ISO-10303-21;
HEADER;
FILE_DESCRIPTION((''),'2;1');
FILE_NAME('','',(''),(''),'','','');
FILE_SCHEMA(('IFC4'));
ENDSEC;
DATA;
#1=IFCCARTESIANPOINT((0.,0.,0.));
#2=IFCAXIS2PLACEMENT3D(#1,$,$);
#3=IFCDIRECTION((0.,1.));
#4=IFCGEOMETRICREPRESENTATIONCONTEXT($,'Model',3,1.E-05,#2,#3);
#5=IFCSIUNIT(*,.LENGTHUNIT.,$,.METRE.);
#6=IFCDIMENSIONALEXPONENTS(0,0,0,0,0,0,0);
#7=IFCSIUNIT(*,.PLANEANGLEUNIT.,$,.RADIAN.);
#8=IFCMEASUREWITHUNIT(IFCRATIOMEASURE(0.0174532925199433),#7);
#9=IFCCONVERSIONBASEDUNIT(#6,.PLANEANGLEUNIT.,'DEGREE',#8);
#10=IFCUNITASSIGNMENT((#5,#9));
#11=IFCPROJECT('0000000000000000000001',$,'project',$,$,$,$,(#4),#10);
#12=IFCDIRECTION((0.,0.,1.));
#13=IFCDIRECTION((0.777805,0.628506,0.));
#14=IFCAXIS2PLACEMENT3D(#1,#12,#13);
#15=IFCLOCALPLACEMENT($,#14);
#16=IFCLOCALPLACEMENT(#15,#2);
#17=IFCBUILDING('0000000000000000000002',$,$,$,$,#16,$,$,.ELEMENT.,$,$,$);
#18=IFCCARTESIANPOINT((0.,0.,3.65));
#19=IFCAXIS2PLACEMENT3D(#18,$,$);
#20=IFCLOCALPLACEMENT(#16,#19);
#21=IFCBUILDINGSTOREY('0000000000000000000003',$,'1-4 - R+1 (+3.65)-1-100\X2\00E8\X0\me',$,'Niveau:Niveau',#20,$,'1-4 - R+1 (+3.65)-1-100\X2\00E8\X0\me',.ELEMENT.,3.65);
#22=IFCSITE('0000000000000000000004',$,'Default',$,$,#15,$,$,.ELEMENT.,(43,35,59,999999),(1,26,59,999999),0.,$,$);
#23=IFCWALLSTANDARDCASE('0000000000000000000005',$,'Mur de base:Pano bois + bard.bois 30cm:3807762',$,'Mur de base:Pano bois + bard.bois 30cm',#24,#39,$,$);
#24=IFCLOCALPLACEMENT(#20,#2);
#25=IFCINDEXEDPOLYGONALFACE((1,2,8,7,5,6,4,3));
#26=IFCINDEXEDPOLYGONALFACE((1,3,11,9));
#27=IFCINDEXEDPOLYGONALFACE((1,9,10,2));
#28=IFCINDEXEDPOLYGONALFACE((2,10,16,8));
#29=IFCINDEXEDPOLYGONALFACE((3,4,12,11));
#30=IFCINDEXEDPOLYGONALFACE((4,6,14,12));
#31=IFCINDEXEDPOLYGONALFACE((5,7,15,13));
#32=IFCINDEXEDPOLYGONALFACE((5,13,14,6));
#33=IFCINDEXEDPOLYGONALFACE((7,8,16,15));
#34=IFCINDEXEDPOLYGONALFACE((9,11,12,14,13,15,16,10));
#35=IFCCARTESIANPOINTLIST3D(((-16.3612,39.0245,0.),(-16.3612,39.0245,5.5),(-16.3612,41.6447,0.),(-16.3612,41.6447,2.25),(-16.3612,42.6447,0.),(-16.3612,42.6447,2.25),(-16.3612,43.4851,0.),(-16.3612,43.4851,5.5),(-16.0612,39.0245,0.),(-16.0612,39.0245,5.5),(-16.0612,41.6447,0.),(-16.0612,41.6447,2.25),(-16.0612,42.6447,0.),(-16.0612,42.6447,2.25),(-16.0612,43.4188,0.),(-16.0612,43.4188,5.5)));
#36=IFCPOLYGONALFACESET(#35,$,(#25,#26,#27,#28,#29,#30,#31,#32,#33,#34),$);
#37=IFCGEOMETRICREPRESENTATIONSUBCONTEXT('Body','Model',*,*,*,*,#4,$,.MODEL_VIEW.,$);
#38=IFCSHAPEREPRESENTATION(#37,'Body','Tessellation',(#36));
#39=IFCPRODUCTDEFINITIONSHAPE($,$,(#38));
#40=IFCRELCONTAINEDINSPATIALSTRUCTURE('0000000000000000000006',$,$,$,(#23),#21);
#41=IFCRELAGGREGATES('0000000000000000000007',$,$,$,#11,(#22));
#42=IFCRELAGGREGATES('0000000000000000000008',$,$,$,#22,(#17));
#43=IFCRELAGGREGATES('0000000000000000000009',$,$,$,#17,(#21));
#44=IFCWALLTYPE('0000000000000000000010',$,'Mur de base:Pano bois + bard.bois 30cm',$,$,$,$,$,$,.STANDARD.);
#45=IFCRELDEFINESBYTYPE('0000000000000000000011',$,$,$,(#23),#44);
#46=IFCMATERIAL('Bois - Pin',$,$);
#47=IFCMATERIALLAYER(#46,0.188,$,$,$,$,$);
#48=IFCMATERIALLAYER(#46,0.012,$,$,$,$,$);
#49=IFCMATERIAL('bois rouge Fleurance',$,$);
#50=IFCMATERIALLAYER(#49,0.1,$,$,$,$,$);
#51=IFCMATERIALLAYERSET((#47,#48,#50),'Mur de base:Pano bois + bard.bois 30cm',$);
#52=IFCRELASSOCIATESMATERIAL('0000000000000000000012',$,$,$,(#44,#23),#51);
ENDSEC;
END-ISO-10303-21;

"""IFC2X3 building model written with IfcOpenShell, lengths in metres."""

from ifc_helpers import new_model, entity, si_unit, converted_unit, direction, frame, frame_2d, origin, place, context, subcontext, project, spatial, polyline, rectangle, outline, extrude, material, layer, layer_set, layer_usage, type_object, element, save


model = new_model("IFC2X3")

# Units and contexts
model_context = context("Model", 3, precision=1e-05, world=origin(), true_north=direction((0.0, 1.0)))
body_context = subcontext(model_context, "Body", "Model", "MODEL_VIEW")
ifc_project = project(units=[si_unit("LENGTHUNIT", "METRE"), converted_unit("PLANEANGLEUNIT", "DEGREE", entity("IfcRatioMeasure", 0.0174532925199433), si_unit("PLANEANGLEUNIT", "RADIAN"), dimensions=[0, 0, 0, 0, 0, 0, 0])], contexts=[model_context])

# Site, building, storey
site_placement = place(None, frame((0.0, 0.0, 0.0), z_axis=(0.0, 0.0, 1.0), x_axis=(0.777805, 0.628506, 0.0)))
site = spatial("IfcSite", under=ifc_project, at=site_placement, Name="Default", CompositionType="ELEMENT", RefLatitude=(43, 35, 59, 999999), RefLongitude=(1, 26, 59, 999999), RefElevation=0.0)
building_placement = place(site_placement, origin())
building = spatial("IfcBuilding", under=site, at=building_placement, CompositionType="ELEMENT")
storey_placement = place(building_placement, frame((0.0, 0.0, 3.65)))
storey = spatial("IfcBuildingStorey", under=building, at=storey_placement, Name="1-4 - R+1 (+3.65)-1-100ème", ObjectType="Niveau:Niveau", LongName="1-4 - R+1 (+3.65)-1-100ème", CompositionType="ELEMENT", Elevation=3.65)

# Shared definitions
ifc_material_1 = material(Name="Bois - Pin")
ifc_material_2 = material(Name="bois rouge Fleurance")

# Wall, opening
ifc_layer_1 = layer(ifc_material_1, 0.188)
ifc_layer_2 = layer(ifc_material_1, 0.012)
ifc_layer_3 = layer(ifc_material_2, 0.1)
ifc_layer_set_1 = layer_set([ifc_layer_1, ifc_layer_2, ifc_layer_3], Name="Mur de base:Pano bois + bard.bois 30cm")
ifc_layer_usage_1 = layer_usage(ifc_layer_set_1, "AXIS2", "POSITIVE", -0.15)
wall_type_1 = type_object("IfcWallType", Name="Mur de base:Pano bois + bard.bois 30cm", PredefinedType="STANDARD", material=ifc_layer_set_1)
wall_1_placement = place(storey_placement, frame((-16.2112, 43.4851, 0.0), z_axis=(0.0, 0.0, 1.0), x_axis=(0.0, -1.0, 0.0)))
wall_1 = element("IfcWallStandardCase", 1, at=wall_1_placement, inside=storey, type_object=wall_type_1, material=ifc_layer_usage_1, Name="Mur de base:Pano bois + bard.bois 30cm:3807762", ObjectType="Mur de base:Pano bois + bard.bois 30cm", context=body_context, shape_type="SweptSolid", body=[
    extrude(outline(polyline([(0.0, -0.15), (4.4607, -0.15), (4.4607, 0.15), (0.0664, 0.15), (0.0, -0.15)])), origin(), (0.0, 0.0, 1.0), 5.5),
])
opening_1_placement = place(wall_1_placement, origin())
element("IfcOpeningElement", 2, at=opening_1_placement, cuts=wall_1, ObjectType="Opening", context=body_context, shape_type="SweptSolid", body=[
    extrude(rectangle(XDim=2.25, YDim=1.0, at=frame_2d((0.0, 0.0), x_axis=(1.0, 0.0))), frame((1.3404, -0.15, 1.125), z_axis=(0.0, 1.0, 0.0), x_axis=(0.0, 0.0, -1.0)), (0.0, 0.0, 1.0), 0.3),
])

save(model, "model.ifc")
